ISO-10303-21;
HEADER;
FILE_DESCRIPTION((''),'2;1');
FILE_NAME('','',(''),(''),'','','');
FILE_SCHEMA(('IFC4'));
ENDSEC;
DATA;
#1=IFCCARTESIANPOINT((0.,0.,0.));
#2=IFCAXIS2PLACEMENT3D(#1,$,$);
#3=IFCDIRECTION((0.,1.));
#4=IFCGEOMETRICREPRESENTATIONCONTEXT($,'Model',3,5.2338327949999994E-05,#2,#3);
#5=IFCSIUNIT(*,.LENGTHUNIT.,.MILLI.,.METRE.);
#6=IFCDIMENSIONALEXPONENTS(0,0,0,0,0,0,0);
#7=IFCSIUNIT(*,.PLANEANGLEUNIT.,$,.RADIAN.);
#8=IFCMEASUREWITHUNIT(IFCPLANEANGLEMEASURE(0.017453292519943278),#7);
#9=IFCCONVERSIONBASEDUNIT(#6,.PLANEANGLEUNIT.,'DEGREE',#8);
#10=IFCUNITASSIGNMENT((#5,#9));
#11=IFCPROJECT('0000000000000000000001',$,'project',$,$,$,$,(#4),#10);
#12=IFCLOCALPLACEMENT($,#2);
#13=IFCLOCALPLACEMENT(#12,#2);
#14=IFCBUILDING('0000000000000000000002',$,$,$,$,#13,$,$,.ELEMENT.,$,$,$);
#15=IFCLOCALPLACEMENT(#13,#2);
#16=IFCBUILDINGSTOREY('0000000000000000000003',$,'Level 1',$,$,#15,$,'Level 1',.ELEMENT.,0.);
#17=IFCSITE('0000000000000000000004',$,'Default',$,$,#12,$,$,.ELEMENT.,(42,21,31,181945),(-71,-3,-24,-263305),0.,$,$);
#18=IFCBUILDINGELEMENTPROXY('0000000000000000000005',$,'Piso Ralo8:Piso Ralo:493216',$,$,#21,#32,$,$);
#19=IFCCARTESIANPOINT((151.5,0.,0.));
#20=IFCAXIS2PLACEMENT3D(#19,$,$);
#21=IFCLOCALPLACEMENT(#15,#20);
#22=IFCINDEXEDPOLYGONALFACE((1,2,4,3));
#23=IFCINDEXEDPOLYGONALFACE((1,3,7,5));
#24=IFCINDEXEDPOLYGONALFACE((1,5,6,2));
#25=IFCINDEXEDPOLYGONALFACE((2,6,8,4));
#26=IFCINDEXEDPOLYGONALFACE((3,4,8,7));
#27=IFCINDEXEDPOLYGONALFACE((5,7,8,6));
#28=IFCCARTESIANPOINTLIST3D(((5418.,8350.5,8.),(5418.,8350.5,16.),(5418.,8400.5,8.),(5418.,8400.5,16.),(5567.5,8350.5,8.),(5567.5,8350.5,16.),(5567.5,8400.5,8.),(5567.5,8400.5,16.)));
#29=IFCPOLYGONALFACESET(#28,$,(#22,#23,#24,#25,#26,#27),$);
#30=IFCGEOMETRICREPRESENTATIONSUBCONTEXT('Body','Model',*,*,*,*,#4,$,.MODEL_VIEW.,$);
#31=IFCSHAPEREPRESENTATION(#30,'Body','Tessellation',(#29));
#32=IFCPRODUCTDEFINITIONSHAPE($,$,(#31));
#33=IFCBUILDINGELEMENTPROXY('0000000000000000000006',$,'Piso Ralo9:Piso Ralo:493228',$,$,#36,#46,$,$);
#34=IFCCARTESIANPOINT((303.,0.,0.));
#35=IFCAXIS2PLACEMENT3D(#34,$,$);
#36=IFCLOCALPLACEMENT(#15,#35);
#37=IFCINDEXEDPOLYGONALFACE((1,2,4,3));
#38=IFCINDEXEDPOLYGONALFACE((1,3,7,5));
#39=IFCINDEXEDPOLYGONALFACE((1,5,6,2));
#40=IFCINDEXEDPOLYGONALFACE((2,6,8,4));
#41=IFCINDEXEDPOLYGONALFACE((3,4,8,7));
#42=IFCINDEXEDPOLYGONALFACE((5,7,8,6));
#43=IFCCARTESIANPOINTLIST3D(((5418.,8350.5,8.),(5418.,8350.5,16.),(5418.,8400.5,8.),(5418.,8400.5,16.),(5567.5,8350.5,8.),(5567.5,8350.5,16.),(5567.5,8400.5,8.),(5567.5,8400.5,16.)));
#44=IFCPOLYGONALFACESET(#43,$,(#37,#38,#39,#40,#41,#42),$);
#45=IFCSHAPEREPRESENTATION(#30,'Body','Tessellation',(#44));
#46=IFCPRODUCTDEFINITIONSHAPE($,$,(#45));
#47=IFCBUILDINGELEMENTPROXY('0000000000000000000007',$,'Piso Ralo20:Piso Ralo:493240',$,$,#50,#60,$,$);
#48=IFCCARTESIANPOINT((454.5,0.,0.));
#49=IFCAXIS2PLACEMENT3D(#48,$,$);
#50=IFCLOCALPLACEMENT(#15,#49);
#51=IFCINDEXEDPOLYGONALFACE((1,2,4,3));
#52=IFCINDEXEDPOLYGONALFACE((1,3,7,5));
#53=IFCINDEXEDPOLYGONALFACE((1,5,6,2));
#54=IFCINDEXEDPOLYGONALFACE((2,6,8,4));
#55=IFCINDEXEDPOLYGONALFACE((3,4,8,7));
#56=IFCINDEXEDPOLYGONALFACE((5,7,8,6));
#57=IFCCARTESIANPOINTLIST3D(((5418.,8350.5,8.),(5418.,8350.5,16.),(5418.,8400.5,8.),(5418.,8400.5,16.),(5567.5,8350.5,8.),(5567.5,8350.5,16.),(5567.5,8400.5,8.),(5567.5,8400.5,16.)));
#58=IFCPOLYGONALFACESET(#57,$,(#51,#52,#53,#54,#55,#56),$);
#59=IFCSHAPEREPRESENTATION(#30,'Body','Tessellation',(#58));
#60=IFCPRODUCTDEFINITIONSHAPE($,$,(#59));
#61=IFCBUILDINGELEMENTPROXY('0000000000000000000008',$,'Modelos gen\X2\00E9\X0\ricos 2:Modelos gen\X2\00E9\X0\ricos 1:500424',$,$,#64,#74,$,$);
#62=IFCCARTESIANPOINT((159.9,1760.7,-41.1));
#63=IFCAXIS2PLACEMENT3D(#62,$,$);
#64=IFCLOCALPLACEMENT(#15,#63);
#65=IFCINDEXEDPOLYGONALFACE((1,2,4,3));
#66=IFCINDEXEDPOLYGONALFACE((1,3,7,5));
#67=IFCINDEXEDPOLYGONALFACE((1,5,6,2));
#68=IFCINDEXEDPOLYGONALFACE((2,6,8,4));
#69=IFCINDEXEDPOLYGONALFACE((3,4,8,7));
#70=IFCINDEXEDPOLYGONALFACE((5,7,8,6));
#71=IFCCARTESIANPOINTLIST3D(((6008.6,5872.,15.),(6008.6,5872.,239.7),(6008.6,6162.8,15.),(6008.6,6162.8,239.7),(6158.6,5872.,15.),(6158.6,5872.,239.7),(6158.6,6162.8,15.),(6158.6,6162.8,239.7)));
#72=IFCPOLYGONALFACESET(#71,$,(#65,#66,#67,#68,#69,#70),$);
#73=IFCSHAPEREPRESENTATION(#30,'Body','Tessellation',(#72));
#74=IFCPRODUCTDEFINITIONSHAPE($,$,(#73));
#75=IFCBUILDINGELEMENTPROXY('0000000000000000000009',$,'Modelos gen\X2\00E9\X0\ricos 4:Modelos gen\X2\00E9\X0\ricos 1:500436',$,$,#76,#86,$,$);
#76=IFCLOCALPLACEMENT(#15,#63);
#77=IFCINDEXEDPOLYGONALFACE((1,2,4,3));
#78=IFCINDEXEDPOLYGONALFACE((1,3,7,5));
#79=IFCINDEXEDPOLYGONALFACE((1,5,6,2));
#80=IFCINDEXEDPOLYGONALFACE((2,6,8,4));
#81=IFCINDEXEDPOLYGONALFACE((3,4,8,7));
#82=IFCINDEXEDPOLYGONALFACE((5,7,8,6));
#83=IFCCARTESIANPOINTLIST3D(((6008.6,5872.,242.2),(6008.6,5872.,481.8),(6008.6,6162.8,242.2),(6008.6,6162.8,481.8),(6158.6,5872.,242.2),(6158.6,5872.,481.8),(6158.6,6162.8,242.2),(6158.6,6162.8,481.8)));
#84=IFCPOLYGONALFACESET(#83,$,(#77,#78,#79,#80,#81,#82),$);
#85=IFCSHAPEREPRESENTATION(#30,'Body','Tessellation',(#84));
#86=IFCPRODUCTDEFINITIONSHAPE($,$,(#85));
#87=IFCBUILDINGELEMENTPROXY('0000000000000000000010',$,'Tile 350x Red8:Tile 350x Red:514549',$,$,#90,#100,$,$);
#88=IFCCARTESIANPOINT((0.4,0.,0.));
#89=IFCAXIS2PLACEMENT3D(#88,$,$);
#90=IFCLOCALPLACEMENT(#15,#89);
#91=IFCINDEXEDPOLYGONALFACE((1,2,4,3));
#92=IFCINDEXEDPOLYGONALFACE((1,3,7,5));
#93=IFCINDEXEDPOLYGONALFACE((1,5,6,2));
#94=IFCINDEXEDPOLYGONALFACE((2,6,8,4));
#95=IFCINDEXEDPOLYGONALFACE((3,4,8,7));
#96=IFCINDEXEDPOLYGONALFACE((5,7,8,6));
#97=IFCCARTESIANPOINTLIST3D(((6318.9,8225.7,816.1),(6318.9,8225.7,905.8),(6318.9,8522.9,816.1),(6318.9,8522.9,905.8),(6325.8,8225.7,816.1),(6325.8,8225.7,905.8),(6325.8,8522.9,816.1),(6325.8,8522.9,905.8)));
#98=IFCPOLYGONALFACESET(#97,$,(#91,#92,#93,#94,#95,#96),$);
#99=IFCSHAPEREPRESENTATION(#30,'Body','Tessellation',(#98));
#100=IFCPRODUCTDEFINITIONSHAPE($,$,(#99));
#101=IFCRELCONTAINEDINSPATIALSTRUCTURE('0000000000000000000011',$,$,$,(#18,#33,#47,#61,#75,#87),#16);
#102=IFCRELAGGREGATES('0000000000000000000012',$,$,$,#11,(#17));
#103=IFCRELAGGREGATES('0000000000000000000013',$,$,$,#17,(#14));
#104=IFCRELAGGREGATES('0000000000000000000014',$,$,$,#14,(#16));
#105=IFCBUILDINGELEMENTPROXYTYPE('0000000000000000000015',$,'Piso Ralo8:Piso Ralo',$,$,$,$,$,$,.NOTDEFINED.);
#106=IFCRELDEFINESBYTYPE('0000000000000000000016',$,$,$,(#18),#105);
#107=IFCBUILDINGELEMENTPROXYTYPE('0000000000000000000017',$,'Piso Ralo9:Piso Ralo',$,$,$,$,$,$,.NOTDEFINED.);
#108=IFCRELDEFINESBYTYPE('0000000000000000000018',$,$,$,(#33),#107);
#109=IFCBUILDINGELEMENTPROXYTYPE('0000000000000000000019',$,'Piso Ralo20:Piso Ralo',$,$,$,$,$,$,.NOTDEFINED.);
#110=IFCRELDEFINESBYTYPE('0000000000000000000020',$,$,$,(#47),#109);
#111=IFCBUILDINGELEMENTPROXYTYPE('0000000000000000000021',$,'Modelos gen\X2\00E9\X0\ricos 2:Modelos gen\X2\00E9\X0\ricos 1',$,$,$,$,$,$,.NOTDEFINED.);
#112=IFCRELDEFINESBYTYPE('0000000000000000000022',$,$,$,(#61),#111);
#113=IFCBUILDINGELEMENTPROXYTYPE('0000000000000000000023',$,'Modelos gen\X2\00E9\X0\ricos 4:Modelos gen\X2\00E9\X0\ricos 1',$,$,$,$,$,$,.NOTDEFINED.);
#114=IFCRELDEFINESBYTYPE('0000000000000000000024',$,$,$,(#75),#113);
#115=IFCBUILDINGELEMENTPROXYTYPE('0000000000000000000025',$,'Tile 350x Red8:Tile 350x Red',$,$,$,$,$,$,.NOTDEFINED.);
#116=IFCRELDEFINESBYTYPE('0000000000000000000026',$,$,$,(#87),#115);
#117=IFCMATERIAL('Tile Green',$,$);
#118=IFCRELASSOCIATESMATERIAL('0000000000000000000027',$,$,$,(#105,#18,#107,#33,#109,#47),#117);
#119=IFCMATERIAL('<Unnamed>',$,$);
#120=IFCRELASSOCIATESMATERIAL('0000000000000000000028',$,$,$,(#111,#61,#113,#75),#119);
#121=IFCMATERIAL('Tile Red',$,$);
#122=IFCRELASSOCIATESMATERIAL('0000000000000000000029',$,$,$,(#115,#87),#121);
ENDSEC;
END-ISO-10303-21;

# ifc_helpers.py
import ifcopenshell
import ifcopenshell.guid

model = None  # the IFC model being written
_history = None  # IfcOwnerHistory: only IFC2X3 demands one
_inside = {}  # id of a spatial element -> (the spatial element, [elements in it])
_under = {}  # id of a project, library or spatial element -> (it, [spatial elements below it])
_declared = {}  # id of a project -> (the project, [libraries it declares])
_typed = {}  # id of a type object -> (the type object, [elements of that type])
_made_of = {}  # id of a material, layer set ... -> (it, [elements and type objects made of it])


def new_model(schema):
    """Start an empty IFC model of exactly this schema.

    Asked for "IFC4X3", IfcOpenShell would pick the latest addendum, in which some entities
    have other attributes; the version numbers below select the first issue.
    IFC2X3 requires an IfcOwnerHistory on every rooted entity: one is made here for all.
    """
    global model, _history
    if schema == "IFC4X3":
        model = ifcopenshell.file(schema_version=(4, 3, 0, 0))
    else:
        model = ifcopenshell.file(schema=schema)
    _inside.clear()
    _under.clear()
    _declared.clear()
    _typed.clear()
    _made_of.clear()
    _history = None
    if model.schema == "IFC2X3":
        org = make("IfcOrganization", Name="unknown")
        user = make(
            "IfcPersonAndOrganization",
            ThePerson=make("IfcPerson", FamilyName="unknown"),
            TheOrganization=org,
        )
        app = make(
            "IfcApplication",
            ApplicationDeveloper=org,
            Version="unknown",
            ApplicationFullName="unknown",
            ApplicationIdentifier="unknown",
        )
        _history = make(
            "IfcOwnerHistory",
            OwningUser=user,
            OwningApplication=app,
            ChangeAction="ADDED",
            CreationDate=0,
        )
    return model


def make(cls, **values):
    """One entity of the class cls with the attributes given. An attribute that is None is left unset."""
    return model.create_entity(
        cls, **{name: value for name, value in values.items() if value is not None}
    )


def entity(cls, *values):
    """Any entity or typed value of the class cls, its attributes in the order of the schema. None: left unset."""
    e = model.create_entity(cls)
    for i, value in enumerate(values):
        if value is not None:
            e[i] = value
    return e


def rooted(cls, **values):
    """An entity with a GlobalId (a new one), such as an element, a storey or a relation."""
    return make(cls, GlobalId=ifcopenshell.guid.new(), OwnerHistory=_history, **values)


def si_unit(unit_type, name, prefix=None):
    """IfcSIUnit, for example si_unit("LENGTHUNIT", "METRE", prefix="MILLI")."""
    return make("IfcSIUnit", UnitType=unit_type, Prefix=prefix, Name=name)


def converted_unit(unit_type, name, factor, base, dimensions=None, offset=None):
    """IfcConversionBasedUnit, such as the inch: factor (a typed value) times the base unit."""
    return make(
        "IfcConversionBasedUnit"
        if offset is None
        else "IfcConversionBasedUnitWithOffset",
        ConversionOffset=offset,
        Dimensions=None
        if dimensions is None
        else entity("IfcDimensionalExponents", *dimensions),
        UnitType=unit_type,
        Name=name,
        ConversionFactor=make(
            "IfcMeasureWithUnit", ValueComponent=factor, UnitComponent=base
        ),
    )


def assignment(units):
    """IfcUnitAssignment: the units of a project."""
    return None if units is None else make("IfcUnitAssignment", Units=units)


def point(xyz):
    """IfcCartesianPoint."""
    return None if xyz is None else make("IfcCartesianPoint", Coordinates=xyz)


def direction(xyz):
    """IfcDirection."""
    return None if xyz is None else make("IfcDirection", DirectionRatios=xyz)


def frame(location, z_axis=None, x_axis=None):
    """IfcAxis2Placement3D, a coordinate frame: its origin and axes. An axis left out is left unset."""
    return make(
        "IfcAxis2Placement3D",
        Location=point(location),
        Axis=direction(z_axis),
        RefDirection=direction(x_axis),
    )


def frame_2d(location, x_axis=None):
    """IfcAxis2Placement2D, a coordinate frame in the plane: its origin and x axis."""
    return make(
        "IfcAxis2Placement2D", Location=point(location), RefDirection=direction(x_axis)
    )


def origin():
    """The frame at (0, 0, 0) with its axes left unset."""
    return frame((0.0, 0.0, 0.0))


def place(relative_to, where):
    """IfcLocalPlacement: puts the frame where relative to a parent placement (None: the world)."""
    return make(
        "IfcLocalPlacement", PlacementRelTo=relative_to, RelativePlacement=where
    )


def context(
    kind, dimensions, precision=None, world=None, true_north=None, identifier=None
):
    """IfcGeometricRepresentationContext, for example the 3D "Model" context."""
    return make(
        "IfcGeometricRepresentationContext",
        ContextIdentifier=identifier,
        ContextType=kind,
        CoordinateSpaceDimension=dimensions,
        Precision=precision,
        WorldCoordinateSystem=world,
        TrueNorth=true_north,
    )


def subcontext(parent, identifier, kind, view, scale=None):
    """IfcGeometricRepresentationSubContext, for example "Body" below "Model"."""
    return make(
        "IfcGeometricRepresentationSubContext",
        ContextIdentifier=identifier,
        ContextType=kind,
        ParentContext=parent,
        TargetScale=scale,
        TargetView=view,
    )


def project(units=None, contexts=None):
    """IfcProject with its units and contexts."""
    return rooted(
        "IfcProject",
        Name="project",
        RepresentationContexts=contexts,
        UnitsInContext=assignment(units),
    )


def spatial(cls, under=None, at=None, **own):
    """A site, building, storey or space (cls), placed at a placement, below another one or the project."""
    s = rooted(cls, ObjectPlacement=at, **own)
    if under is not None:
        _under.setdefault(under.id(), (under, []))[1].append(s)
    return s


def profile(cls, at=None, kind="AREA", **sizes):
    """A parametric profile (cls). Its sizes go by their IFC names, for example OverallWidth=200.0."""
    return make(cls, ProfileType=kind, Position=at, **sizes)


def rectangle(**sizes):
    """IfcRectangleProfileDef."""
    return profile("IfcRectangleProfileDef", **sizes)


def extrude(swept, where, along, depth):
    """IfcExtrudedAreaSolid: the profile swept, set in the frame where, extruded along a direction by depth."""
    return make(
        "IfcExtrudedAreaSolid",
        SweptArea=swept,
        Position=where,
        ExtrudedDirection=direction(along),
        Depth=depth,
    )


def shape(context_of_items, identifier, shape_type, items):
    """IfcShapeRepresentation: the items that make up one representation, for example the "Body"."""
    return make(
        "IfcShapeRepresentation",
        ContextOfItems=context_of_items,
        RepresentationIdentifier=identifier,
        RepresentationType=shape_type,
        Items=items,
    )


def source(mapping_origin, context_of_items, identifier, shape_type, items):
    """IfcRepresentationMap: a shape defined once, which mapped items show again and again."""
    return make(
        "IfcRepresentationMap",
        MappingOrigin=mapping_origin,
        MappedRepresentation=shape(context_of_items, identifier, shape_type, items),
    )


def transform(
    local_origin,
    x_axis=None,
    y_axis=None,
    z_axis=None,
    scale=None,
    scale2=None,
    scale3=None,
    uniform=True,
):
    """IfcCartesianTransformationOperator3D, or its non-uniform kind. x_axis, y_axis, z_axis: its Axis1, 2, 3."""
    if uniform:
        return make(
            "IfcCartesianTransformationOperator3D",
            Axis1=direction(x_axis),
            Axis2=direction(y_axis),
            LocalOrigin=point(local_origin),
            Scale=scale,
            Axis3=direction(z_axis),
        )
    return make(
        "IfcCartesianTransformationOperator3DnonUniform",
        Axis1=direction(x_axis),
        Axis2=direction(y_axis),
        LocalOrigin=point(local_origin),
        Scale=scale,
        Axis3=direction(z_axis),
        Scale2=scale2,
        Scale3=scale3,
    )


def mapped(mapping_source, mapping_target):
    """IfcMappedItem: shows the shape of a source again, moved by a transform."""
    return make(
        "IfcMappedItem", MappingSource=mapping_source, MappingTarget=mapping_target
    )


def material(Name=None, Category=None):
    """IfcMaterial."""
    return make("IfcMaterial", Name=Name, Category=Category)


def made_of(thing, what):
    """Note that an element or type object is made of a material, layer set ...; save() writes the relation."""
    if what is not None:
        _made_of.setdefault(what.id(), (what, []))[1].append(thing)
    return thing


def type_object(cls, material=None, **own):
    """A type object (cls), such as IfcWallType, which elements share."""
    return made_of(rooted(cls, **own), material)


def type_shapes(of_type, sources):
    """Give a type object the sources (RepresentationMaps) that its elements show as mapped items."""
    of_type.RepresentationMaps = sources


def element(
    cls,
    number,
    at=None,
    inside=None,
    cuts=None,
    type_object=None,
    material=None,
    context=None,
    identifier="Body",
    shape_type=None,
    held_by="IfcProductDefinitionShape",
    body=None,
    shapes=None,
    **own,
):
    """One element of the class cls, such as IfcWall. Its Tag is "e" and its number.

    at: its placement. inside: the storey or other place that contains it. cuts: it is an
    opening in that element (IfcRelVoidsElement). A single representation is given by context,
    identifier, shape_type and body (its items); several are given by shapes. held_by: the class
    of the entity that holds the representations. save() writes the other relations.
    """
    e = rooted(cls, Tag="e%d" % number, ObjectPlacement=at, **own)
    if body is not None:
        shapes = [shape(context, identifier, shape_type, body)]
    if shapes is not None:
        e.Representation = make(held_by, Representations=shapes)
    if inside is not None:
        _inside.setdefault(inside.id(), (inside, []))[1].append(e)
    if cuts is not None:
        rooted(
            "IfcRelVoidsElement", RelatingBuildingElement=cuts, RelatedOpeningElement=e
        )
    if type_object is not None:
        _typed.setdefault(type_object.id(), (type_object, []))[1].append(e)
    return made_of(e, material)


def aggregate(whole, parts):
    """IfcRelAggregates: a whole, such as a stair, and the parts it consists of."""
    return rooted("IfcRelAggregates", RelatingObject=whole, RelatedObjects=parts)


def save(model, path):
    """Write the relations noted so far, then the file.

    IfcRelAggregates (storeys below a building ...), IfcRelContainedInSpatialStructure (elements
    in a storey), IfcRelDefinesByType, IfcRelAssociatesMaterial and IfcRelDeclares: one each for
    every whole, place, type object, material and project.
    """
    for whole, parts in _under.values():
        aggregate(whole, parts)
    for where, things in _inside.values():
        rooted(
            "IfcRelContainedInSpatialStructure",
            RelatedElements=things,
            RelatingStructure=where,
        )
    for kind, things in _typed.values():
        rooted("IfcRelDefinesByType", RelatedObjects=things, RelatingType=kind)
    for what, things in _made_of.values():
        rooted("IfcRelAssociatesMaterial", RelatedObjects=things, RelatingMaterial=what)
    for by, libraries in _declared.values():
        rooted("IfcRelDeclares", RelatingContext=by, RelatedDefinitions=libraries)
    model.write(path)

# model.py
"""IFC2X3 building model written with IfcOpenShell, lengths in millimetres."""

from ifc_helpers import new_model, entity, si_unit, converted_unit, direction, frame, frame_2d, origin, place, context, subcontext, project, spatial, rectangle, extrude, source, transform, mapped, material, type_object, type_shapes, element, save


model = new_model("IFC2X3")

# Units and contexts
model_context = context("Model", 3, precision=5.2338327949999994e-05, world=origin(), true_north=direction((0.0, 1.0)))
body_context = subcontext(model_context, "Body", "Model", "MODEL_VIEW")
ifc_project = project(units=[si_unit("LENGTHUNIT", "METRE", prefix="MILLI"), converted_unit("PLANEANGLEUNIT", "DEGREE", entity("IfcPlaneAngleMeasure", 0.017453292519943278), si_unit("PLANEANGLEUNIT", "RADIAN"), dimensions=[0, 0, 0, 0, 0, 0, 0])], contexts=[model_context])

# Site, building, storey
site_placement = place(None, origin())
site = spatial("IfcSite", under=ifc_project, at=site_placement, Name="Default", CompositionType="ELEMENT", RefLatitude=(42, 21, 31, 181945), RefLongitude=(-71, -3, -24, -263305), RefElevation=0.0)
building_placement = place(site_placement, origin())
building = spatial("IfcBuilding", under=site, at=building_placement, CompositionType="ELEMENT")
storey_placement = place(building_placement, origin())
storey = spatial("IfcBuildingStorey", under=building, at=storey_placement, Name="Level 1", LongName="Level 1", CompositionType="ELEMENT", Elevation=0.0)

# Building element proxies
ifc_material_1 = material(Name="Tile Green")
building_element_proxy_type_1 = type_object("IfcBuildingElementProxyType", Name="Piso Ralo8:Piso Ralo", PredefinedType="NOTDEFINED", material=ifc_material_1)
shared_shape_1 = source(origin(), body_context, "Body", "SweptSolid", [
    extrude(rectangle(XDim=149.5, YDim=50.0, at=frame_2d((0.0, 0.0), x_axis=(1.0, 0.0))), frame((5492.7, 8375.5, 8.0), z_axis=(0.0, 0.0, 1.0), x_axis=(-1.0, 0.0, 0.0)), (0.0, 0.0, 1.0), 8.0),
])
type_shapes(building_element_proxy_type_1, [shared_shape_1])
proxy_1_placement = place(storey_placement, frame((151.5, 0.0, 0.0)))
element("IfcBuildingElementProxy", 1, at=proxy_1_placement, inside=storey, type_object=building_element_proxy_type_1, material=ifc_material_1, Name="Piso Ralo8:Piso Ralo:493216", context=body_context, shape_type="MappedRepresentation", body=[
    mapped(shared_shape_1, transform((0.0, 0.0, 0.0), scale=1.0)),
])
building_element_proxy_type_2 = type_object("IfcBuildingElementProxyType", Name="Piso Ralo9:Piso Ralo", PredefinedType="NOTDEFINED", material=ifc_material_1)
shared_shape_2 = source(origin(), body_context, "Body", "SweptSolid", [
    extrude(rectangle(XDim=149.5, YDim=50.0, at=frame_2d((0.0, 0.0), x_axis=(1.0, 0.0))), frame((5492.7, 8375.5, 8.0), z_axis=(0.0, 0.0, 1.0), x_axis=(-1.0, 0.0, 0.0)), (0.0, 0.0, 1.0), 8.0),
])
type_shapes(building_element_proxy_type_2, [shared_shape_2])
proxy_2_placement = place(storey_placement, frame((303.0, 0.0, 0.0)))
element("IfcBuildingElementProxy", 2, at=proxy_2_placement, inside=storey, type_object=building_element_proxy_type_2, material=ifc_material_1, Name="Piso Ralo9:Piso Ralo:493228", context=body_context, shape_type="MappedRepresentation", body=[
    mapped(shared_shape_2, transform((0.0, 0.0, 0.0), scale=1.0)),
])
building_element_proxy_type_3 = type_object("IfcBuildingElementProxyType", Name="Piso Ralo20:Piso Ralo", PredefinedType="NOTDEFINED", material=ifc_material_1)
shared_shape_3 = source(origin(), body_context, "Body", "SweptSolid", [
    extrude(rectangle(XDim=149.5, YDim=50.0, at=frame_2d((0.0, 0.0), x_axis=(1.0, 0.0))), frame((5492.7, 8375.5, 8.0), z_axis=(0.0, 0.0, 1.0), x_axis=(-1.0, 0.0, 0.0)), (0.0, 0.0, 1.0), 8.0),
])
type_shapes(building_element_proxy_type_3, [shared_shape_3])
proxy_3_placement = place(storey_placement, frame((454.5, 0.0, 0.0)))
element("IfcBuildingElementProxy", 3, at=proxy_3_placement, inside=storey, type_object=building_element_proxy_type_3, material=ifc_material_1, Name="Piso Ralo20:Piso Ralo:493240", context=body_context, shape_type="MappedRepresentation", body=[
    mapped(shared_shape_3, transform((0.0, 0.0, 0.0), scale=1.0)),
])
ifc_material_2 = material(Name="<Unnamed>")
building_element_proxy_type_4 = type_object("IfcBuildingElementProxyType", Name="Modelos genéricos 2:Modelos genéricos 1", PredefinedType="NOTDEFINED", material=ifc_material_2)
shared_shape_4 = source(origin(), body_context, "Body", "SweptSolid", [
    extrude(rectangle(XDim=150.0, YDim=290.8, at=frame_2d((0.0, 0.0), x_axis=(1.0, 0.0))), frame((6083.6, 6017.4, 15.0), z_axis=(0.0, 0.0, 1.0), x_axis=(-1.0, 0.0, 0.0)), (0.0, 0.0, 1.0), 224.7),
])
type_shapes(building_element_proxy_type_4, [shared_shape_4])
proxy_4_placement = place(storey_placement, frame((159.9, 1760.7, -41.1)))
element("IfcBuildingElementProxy", 4, at=proxy_4_placement, inside=storey, type_object=building_element_proxy_type_4, material=ifc_material_2, Name="Modelos genéricos 2:Modelos genéricos 1:500424", context=body_context, shape_type="MappedRepresentation", body=[
    mapped(shared_shape_4, transform((0.0, 0.0, 0.0), scale=1.0)),
])
building_element_proxy_type_5 = type_object("IfcBuildingElementProxyType", Name="Modelos genéricos 4:Modelos genéricos 1", PredefinedType="NOTDEFINED", material=ifc_material_2)
shared_shape_5 = source(origin(), body_context, "Body", "SweptSolid", [
    extrude(rectangle(XDim=150.0, YDim=290.8, at=frame_2d((0.0, 0.0), x_axis=(1.0, 0.0))), frame((6083.6, 6017.4, 242.2), z_axis=(0.0, 0.0, 1.0), x_axis=(-1.0, 0.0, 0.0)), (0.0, 0.0, 1.0), 239.6),
])
type_shapes(building_element_proxy_type_5, [shared_shape_5])
proxy_5_placement = place(storey_placement, frame((159.9, 1760.7, -41.1)))
element("IfcBuildingElementProxy", 5, at=proxy_5_placement, inside=storey, type_object=building_element_proxy_type_5, material=ifc_material_2, Name="Modelos genéricos 4:Modelos genéricos 1:500436", context=body_context, shape_type="MappedRepresentation", body=[
    mapped(shared_shape_5, transform((0.0, 0.0, 0.0), scale=1.0)),
])
ifc_material_3 = material(Name="Tile Red")
building_element_proxy_type_6 = type_object("IfcBuildingElementProxyType", Name="Tile 350x Red8:Tile 350x Red", PredefinedType="NOTDEFINED", material=ifc_material_3)
shared_shape_6 = source(origin(), body_context, "Body", "SweptSolid", [
    extrude(rectangle(XDim=6.9, YDim=297.1, at=frame_2d((0.0, 0.0), x_axis=(1.0, 0.0))), frame((6322.4, 8374.3, 816.1), z_axis=(0.0, 0.0, 1.0), x_axis=(-1.0, 0.0, 0.0)), (0.0, 0.0, 1.0), 89.7),
])
type_shapes(building_element_proxy_type_6, [shared_shape_6])
proxy_6_placement = place(storey_placement, frame((0.4, 0.0, 0.0)))
element("IfcBuildingElementProxy", 6, at=proxy_6_placement, inside=storey, type_object=building_element_proxy_type_6, material=ifc_material_3, Name="Tile 350x Red8:Tile 350x Red:514549", context=body_context, shape_type="MappedRepresentation", body=[
    mapped(shared_shape_6, transform((0.0, 0.0, 0.0), scale=1.0)),
])

save(model, "model.ifc")
